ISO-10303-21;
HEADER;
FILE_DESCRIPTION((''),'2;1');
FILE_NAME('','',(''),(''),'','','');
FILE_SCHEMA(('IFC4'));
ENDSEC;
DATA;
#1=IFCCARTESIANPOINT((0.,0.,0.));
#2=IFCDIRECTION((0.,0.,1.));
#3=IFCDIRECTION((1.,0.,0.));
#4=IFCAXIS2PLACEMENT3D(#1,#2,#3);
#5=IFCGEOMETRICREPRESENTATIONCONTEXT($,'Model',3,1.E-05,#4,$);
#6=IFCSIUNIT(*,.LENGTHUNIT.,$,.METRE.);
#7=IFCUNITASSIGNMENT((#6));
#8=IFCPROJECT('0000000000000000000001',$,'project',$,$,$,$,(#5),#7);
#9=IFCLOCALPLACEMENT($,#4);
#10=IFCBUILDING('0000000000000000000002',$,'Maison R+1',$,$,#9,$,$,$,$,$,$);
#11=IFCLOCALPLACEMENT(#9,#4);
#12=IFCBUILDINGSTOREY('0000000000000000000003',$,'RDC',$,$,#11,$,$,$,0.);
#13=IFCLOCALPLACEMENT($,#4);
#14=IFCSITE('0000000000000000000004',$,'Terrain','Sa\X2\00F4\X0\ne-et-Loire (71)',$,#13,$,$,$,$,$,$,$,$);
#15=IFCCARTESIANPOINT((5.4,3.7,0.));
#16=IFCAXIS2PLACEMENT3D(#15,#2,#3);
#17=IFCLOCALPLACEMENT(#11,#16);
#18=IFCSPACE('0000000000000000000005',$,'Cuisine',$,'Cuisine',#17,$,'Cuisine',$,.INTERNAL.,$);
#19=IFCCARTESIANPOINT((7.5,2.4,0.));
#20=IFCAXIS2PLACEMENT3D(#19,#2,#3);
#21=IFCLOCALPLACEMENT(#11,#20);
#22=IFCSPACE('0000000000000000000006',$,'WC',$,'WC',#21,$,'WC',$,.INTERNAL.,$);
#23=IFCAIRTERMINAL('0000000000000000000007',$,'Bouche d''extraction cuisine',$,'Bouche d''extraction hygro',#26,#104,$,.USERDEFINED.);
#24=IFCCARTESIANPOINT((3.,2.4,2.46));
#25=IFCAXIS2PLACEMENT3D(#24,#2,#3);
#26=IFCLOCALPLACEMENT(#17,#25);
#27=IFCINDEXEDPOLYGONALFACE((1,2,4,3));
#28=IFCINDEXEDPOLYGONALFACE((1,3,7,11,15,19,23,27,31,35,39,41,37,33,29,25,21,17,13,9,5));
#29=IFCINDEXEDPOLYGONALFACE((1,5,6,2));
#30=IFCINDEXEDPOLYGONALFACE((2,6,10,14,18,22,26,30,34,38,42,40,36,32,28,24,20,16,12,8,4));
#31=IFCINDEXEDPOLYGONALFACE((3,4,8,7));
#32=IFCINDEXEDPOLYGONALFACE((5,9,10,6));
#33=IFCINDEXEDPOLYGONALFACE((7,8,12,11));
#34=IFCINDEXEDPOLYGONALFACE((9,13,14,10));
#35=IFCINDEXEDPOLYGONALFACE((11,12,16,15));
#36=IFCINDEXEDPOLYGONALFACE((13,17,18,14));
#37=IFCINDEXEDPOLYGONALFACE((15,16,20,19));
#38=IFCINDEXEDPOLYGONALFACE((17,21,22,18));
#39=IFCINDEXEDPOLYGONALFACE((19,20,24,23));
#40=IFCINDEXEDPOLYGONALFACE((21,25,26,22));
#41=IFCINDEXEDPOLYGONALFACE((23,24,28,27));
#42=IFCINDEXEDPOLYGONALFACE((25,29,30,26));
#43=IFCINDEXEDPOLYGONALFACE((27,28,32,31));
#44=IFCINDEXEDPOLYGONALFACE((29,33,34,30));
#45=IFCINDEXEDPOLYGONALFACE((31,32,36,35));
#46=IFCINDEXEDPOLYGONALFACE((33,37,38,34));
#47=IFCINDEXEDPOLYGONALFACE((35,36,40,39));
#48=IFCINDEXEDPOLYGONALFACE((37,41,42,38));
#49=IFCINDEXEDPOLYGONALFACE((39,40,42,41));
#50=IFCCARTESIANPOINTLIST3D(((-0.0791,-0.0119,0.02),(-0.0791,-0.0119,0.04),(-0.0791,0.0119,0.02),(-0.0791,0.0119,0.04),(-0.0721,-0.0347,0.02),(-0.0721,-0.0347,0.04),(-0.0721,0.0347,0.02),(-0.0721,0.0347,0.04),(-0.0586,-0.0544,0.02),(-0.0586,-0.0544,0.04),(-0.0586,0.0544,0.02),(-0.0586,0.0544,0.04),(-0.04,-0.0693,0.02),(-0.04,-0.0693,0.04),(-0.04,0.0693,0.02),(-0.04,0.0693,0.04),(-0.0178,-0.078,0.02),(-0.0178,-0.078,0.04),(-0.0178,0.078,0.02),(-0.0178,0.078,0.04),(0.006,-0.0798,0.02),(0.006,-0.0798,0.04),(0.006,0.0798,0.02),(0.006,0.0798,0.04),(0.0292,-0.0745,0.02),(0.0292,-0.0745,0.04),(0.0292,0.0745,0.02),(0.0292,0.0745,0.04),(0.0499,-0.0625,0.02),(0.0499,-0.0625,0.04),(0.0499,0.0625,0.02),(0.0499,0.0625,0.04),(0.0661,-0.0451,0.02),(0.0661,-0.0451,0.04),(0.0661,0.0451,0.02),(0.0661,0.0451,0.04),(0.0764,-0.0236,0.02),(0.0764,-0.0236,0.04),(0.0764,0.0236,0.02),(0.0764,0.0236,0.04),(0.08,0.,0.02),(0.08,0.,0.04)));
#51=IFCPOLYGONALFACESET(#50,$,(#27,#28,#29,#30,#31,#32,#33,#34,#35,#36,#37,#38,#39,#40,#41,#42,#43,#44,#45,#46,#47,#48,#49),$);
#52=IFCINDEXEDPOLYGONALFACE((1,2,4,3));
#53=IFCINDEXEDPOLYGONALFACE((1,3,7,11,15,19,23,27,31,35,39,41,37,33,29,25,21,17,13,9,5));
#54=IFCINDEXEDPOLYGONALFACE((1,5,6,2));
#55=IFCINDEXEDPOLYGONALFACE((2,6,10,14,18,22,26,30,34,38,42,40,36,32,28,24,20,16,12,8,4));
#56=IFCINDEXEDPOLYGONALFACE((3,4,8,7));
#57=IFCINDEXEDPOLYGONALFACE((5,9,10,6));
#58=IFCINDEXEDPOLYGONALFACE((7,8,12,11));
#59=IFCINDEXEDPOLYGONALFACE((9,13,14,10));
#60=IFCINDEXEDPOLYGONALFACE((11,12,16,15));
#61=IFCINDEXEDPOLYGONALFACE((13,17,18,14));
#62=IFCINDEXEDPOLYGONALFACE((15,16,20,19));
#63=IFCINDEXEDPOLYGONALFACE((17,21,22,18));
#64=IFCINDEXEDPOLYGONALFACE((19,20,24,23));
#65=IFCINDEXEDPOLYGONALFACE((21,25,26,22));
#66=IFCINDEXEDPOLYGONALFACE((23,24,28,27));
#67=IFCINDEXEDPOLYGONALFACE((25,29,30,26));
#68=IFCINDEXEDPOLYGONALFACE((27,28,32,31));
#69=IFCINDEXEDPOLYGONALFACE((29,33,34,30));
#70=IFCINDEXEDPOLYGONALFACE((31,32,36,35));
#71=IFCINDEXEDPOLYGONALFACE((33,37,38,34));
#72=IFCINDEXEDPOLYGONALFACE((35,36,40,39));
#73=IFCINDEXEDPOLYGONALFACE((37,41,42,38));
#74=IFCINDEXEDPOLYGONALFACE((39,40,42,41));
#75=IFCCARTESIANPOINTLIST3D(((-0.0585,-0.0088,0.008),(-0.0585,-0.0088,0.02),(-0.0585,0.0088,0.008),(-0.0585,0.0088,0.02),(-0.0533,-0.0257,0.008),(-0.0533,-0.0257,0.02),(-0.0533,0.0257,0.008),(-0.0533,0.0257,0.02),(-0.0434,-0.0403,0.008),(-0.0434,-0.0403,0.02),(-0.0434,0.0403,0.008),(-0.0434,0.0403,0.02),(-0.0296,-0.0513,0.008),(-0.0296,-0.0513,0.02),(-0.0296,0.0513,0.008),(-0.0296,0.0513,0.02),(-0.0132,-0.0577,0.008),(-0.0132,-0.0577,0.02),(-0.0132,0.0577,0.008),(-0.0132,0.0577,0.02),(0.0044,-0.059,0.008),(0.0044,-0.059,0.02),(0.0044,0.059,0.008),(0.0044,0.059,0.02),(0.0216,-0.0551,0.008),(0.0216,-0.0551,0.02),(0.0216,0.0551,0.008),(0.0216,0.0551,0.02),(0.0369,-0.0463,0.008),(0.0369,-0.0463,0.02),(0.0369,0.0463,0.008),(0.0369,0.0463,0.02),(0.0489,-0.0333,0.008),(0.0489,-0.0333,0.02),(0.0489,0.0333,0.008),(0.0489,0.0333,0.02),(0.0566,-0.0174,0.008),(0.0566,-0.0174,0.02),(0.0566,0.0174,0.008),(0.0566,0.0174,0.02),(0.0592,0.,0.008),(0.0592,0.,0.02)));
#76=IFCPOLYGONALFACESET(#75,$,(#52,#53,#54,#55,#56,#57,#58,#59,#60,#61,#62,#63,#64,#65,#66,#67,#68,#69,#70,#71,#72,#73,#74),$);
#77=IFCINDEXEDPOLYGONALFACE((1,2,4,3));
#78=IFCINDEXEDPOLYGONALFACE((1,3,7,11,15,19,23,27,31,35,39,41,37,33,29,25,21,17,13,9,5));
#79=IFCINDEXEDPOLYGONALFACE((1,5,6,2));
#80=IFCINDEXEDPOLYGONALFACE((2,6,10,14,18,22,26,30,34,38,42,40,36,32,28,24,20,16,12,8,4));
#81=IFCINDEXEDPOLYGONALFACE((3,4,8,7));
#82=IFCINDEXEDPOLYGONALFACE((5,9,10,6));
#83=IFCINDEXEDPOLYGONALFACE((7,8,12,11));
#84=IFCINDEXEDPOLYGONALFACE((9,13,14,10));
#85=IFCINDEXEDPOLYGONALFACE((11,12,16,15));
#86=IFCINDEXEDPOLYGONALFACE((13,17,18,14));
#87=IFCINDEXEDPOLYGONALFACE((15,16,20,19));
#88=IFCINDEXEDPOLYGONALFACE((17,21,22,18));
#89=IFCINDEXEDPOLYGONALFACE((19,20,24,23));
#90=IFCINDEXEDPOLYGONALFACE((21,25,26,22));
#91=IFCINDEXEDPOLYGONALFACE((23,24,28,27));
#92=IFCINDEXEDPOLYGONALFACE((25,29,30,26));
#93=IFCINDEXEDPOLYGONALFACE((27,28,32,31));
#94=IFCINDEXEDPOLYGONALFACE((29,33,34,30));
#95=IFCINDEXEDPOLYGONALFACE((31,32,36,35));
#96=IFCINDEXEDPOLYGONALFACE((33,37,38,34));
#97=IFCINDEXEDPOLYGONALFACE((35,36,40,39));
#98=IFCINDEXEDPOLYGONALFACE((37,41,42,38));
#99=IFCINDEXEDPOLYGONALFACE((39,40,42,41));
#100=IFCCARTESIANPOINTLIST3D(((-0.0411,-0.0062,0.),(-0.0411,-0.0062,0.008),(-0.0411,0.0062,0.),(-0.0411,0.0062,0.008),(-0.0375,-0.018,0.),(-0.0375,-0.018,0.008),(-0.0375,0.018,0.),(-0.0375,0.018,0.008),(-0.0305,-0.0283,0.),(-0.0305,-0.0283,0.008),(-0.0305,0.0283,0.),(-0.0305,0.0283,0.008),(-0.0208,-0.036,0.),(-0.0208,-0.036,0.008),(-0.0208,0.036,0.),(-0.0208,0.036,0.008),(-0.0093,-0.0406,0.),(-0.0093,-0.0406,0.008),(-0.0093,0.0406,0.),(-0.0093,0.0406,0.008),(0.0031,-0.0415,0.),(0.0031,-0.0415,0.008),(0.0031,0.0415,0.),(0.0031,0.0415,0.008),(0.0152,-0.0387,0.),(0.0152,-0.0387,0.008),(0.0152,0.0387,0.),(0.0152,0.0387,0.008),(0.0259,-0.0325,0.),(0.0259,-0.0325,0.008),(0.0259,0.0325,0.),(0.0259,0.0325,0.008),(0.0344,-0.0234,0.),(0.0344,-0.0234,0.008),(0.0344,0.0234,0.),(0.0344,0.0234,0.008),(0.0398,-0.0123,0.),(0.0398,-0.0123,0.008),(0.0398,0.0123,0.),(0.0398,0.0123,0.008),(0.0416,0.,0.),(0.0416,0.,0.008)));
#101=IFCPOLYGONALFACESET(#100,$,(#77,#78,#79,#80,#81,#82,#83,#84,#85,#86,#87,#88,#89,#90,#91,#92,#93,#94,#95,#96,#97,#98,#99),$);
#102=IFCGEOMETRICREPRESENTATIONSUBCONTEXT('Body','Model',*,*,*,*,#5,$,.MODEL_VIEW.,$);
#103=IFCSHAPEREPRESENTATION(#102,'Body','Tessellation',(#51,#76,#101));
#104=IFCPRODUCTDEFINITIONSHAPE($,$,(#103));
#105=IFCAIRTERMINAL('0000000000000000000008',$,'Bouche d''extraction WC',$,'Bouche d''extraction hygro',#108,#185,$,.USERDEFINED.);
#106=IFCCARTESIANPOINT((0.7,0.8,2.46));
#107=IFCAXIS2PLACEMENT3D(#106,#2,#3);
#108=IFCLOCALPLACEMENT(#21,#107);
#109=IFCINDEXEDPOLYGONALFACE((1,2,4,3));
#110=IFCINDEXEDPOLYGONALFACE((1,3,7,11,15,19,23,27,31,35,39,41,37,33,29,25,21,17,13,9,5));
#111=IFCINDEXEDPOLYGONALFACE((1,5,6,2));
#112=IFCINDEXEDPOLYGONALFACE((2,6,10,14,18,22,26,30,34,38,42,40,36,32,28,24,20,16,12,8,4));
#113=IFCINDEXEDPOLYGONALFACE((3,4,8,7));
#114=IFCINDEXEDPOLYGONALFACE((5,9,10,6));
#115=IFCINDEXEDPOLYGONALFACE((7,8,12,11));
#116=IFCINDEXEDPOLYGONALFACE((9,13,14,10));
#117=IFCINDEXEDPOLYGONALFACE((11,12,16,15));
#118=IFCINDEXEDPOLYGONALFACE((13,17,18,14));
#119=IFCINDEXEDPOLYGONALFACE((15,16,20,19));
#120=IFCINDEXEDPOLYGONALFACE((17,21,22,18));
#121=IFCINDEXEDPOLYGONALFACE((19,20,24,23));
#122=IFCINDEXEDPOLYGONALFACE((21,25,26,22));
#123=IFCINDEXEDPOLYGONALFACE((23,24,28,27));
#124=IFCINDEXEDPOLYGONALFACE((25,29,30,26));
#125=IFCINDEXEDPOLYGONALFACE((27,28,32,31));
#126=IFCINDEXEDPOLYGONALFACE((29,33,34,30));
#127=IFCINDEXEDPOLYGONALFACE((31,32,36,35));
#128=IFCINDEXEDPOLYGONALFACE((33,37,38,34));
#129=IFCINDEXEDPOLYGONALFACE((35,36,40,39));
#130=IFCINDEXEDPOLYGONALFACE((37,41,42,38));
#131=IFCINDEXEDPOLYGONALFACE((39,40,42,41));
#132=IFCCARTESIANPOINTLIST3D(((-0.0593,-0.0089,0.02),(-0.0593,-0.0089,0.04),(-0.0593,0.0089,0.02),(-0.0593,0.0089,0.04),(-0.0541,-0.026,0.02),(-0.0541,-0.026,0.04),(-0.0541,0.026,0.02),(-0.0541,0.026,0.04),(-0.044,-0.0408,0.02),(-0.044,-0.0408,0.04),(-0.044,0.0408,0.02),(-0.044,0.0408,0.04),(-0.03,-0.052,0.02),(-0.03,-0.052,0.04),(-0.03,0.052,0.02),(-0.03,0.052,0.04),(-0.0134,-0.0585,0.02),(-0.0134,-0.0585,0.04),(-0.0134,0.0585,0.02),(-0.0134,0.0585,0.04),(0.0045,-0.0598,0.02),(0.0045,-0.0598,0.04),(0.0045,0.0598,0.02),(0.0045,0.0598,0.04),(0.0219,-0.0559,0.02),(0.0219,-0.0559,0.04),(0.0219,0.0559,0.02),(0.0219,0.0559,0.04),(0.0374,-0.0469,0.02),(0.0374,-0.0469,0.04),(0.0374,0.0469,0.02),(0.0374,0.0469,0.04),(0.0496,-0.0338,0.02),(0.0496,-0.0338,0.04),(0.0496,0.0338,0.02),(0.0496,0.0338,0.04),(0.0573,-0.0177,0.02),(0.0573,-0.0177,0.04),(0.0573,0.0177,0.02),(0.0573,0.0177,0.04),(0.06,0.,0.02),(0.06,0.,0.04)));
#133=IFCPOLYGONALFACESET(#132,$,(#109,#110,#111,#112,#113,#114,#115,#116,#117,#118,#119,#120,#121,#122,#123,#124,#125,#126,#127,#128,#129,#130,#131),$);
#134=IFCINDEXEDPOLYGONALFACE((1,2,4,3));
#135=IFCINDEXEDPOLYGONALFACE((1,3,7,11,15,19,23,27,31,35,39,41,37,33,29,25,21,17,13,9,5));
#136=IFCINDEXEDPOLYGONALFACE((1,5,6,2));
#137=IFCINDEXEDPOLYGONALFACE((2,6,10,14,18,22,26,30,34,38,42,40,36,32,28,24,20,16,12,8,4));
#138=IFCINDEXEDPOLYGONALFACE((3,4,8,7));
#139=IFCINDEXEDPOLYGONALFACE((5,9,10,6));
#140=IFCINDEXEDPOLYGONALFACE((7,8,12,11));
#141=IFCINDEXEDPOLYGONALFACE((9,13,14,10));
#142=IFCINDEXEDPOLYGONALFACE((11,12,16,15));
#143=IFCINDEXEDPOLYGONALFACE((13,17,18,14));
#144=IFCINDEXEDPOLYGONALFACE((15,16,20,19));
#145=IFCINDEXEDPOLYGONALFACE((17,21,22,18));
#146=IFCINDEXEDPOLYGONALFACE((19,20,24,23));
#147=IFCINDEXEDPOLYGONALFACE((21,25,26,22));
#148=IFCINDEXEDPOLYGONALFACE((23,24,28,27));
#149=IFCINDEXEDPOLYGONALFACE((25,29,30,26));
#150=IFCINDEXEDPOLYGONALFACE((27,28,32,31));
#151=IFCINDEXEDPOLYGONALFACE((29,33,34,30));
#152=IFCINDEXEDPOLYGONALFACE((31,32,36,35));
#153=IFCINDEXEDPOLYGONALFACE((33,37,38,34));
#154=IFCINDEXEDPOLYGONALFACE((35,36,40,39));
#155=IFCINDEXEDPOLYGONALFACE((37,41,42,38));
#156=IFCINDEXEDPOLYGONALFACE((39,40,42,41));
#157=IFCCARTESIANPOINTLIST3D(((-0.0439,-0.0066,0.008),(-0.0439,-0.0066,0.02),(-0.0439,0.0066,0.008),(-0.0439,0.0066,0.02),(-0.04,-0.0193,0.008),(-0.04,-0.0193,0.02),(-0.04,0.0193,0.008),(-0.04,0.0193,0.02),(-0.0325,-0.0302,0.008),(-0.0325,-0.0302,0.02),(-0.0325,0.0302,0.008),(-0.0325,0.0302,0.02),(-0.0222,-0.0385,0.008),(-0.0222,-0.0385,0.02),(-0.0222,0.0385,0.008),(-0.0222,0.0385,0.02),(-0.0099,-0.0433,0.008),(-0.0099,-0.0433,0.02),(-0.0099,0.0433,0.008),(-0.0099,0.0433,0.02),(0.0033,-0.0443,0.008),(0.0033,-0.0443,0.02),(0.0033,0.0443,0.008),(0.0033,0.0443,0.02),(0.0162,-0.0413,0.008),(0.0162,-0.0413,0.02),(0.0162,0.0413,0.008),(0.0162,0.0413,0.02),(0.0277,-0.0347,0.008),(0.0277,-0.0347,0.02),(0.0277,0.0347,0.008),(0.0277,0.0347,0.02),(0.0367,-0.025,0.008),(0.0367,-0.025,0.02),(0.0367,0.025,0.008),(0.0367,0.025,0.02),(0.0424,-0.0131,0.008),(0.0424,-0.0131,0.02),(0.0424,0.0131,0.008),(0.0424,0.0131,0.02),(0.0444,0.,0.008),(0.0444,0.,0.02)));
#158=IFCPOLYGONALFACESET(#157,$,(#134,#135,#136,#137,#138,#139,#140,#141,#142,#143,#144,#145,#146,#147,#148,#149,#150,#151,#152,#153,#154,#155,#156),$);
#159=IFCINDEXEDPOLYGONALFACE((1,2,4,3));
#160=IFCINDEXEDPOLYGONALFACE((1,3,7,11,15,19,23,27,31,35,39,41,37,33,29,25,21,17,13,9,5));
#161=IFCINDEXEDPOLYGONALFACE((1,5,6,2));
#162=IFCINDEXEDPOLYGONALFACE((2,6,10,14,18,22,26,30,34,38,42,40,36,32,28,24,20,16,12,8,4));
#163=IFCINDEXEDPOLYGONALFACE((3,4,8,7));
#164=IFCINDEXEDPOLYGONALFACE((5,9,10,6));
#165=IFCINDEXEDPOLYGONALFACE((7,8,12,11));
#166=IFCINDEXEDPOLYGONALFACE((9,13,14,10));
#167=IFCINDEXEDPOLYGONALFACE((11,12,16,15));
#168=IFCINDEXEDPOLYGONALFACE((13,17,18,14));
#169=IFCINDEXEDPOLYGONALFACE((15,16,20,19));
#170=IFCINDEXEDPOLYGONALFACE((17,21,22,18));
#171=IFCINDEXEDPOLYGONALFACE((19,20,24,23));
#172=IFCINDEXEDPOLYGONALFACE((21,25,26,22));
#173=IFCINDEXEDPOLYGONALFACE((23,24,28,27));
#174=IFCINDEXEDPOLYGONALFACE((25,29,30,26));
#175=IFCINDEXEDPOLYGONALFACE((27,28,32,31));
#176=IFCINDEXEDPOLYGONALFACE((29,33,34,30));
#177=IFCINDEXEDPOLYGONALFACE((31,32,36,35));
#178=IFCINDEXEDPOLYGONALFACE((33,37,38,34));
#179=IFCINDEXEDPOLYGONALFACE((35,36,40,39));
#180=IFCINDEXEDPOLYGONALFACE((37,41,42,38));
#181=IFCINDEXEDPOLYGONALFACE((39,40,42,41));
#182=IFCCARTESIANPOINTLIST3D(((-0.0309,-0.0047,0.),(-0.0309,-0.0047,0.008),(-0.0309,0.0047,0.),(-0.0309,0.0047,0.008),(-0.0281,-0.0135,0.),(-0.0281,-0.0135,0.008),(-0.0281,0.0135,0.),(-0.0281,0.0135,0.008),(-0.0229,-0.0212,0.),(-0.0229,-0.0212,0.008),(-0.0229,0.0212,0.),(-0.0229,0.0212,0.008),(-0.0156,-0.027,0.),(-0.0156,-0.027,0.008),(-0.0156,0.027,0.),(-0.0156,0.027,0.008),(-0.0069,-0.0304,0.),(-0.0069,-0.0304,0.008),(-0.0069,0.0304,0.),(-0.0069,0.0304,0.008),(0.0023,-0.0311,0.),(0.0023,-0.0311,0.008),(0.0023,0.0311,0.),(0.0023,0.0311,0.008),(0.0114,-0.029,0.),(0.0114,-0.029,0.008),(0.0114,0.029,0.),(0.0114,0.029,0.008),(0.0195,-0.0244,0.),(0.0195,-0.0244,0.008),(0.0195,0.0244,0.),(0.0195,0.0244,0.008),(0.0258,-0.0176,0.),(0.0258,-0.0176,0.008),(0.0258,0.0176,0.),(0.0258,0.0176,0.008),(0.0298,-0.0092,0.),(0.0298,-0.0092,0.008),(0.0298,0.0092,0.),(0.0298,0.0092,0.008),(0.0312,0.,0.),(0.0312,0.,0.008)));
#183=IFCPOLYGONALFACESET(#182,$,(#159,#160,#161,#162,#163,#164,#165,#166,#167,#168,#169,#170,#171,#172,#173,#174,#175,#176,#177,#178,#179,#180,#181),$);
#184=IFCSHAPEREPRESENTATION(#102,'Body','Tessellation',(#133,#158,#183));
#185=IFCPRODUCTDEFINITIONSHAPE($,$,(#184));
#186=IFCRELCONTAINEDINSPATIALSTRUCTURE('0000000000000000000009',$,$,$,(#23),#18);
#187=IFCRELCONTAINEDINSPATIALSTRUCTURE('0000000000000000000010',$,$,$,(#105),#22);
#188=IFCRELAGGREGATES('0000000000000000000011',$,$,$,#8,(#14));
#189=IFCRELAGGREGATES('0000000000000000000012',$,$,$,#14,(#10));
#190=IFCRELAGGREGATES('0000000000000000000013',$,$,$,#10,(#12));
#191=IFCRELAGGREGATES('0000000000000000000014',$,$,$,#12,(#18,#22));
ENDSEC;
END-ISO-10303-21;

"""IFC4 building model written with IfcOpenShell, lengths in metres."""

from ifc_helpers import new_model, si_unit, frame, origin_with_axes, place, context, subcontext, project, spatial, circle, extrude, element, save


model = new_model("IFC4")

# Units and contexts
model_context = context("Model", 3, precision=1e-05, world=origin_with_axes())
body_context = subcontext(model_context, "Body", "Model", "MODEL_VIEW")
ifc_project = project(units=[si_unit("LENGTHUNIT", "METRE")], contexts=[model_context])

# Site, building, storey
site_placement = place(None, origin_with_axes())
site = spatial("IfcSite", under=ifc_project, at=site_placement, Name="Terrain", Description="Saône-et-Loire (71)")
building_placement = place(None, origin_with_axes())
building = spatial("IfcBuilding", under=site, at=building_placement, Name="Maison R+1")
storey_placement = place(building_placement, origin_with_axes())
storey = spatial("IfcBuildingStorey", under=building, at=storey_placement, Name="RDC", Elevation=0.0)

# Shared definitions
space_1_placement = place(storey_placement, frame((5.4, 3.7, 0.0), z_axis=(0.0, 0.0, 1.0), x_axis=(1.0, 0.0, 0.0)))
space_1 = spatial("IfcSpace", under=storey, at=space_1_placement, Name="Cuisine", ObjectType="Cuisine", LongName="Cuisine", PredefinedType="INTERNAL")

# Shared definitions
space_2_placement = place(storey_placement, frame((7.5, 2.4, 0.0), z_axis=(0.0, 0.0, 1.0), x_axis=(1.0, 0.0, 0.0)))
space_2 = spatial("IfcSpace", under=storey, at=space_2_placement, Name="WC", ObjectType="WC", LongName="WC", PredefinedType="INTERNAL")

# Air terminals
air_terminal_1_placement = place(space_1_placement, frame((3.0, 2.4, 2.46), z_axis=(0.0, 0.0, 1.0), x_axis=(1.0, 0.0, 0.0)))
element("IfcAirTerminal", 1, at=air_terminal_1_placement, inside=space_1, Name="Bouche d'extraction cuisine", ObjectType="Bouche d'extraction hygro", PredefinedType="USERDEFINED", context=body_context, shape_type="SweptSolid", body=[
    extrude(circle(Radius=0.08), frame((0.0, 0.0, 0.02), z_axis=(0.0, 0.0, 1.0), x_axis=(1.0, 0.0, 0.0)), (0.0, 0.0, 1.0), 0.02),
    extrude(circle(Radius=0.0592), frame((0.0, 0.0, 0.008), z_axis=(0.0, 0.0, 1.0), x_axis=(1.0, 0.0, 0.0)), (0.0, 0.0, 1.0), 0.012),
    extrude(circle(Radius=0.0416), origin_with_axes(), (0.0, 0.0, 1.0), 0.008),
])
air_terminal_2_placement = place(space_2_placement, frame((0.7, 0.8, 2.46), z_axis=(0.0, 0.0, 1.0), x_axis=(1.0, 0.0, 0.0)))
element("IfcAirTerminal", 2, at=air_terminal_2_placement, inside=space_2, Name="Bouche d'extraction WC", ObjectType="Bouche d'extraction hygro", PredefinedType="USERDEFINED", context=body_context, shape_type="SweptSolid", body=[
    extrude(circle(Radius=0.06), frame((0.0, 0.0, 0.02), z_axis=(0.0, 0.0, 1.0), x_axis=(1.0, 0.0, 0.0)), (0.0, 0.0, 1.0), 0.02),
    extrude(circle(Radius=0.0444), frame((0.0, 0.0, 0.008), z_axis=(0.0, 0.0, 1.0), x_axis=(1.0, 0.0, 0.0)), (0.0, 0.0, 1.0), 0.012),
    extrude(circle(Radius=0.0312), origin_with_axes(), (0.0, 0.0, 1.0), 0.008),
])

save(model, "model.ifc")
